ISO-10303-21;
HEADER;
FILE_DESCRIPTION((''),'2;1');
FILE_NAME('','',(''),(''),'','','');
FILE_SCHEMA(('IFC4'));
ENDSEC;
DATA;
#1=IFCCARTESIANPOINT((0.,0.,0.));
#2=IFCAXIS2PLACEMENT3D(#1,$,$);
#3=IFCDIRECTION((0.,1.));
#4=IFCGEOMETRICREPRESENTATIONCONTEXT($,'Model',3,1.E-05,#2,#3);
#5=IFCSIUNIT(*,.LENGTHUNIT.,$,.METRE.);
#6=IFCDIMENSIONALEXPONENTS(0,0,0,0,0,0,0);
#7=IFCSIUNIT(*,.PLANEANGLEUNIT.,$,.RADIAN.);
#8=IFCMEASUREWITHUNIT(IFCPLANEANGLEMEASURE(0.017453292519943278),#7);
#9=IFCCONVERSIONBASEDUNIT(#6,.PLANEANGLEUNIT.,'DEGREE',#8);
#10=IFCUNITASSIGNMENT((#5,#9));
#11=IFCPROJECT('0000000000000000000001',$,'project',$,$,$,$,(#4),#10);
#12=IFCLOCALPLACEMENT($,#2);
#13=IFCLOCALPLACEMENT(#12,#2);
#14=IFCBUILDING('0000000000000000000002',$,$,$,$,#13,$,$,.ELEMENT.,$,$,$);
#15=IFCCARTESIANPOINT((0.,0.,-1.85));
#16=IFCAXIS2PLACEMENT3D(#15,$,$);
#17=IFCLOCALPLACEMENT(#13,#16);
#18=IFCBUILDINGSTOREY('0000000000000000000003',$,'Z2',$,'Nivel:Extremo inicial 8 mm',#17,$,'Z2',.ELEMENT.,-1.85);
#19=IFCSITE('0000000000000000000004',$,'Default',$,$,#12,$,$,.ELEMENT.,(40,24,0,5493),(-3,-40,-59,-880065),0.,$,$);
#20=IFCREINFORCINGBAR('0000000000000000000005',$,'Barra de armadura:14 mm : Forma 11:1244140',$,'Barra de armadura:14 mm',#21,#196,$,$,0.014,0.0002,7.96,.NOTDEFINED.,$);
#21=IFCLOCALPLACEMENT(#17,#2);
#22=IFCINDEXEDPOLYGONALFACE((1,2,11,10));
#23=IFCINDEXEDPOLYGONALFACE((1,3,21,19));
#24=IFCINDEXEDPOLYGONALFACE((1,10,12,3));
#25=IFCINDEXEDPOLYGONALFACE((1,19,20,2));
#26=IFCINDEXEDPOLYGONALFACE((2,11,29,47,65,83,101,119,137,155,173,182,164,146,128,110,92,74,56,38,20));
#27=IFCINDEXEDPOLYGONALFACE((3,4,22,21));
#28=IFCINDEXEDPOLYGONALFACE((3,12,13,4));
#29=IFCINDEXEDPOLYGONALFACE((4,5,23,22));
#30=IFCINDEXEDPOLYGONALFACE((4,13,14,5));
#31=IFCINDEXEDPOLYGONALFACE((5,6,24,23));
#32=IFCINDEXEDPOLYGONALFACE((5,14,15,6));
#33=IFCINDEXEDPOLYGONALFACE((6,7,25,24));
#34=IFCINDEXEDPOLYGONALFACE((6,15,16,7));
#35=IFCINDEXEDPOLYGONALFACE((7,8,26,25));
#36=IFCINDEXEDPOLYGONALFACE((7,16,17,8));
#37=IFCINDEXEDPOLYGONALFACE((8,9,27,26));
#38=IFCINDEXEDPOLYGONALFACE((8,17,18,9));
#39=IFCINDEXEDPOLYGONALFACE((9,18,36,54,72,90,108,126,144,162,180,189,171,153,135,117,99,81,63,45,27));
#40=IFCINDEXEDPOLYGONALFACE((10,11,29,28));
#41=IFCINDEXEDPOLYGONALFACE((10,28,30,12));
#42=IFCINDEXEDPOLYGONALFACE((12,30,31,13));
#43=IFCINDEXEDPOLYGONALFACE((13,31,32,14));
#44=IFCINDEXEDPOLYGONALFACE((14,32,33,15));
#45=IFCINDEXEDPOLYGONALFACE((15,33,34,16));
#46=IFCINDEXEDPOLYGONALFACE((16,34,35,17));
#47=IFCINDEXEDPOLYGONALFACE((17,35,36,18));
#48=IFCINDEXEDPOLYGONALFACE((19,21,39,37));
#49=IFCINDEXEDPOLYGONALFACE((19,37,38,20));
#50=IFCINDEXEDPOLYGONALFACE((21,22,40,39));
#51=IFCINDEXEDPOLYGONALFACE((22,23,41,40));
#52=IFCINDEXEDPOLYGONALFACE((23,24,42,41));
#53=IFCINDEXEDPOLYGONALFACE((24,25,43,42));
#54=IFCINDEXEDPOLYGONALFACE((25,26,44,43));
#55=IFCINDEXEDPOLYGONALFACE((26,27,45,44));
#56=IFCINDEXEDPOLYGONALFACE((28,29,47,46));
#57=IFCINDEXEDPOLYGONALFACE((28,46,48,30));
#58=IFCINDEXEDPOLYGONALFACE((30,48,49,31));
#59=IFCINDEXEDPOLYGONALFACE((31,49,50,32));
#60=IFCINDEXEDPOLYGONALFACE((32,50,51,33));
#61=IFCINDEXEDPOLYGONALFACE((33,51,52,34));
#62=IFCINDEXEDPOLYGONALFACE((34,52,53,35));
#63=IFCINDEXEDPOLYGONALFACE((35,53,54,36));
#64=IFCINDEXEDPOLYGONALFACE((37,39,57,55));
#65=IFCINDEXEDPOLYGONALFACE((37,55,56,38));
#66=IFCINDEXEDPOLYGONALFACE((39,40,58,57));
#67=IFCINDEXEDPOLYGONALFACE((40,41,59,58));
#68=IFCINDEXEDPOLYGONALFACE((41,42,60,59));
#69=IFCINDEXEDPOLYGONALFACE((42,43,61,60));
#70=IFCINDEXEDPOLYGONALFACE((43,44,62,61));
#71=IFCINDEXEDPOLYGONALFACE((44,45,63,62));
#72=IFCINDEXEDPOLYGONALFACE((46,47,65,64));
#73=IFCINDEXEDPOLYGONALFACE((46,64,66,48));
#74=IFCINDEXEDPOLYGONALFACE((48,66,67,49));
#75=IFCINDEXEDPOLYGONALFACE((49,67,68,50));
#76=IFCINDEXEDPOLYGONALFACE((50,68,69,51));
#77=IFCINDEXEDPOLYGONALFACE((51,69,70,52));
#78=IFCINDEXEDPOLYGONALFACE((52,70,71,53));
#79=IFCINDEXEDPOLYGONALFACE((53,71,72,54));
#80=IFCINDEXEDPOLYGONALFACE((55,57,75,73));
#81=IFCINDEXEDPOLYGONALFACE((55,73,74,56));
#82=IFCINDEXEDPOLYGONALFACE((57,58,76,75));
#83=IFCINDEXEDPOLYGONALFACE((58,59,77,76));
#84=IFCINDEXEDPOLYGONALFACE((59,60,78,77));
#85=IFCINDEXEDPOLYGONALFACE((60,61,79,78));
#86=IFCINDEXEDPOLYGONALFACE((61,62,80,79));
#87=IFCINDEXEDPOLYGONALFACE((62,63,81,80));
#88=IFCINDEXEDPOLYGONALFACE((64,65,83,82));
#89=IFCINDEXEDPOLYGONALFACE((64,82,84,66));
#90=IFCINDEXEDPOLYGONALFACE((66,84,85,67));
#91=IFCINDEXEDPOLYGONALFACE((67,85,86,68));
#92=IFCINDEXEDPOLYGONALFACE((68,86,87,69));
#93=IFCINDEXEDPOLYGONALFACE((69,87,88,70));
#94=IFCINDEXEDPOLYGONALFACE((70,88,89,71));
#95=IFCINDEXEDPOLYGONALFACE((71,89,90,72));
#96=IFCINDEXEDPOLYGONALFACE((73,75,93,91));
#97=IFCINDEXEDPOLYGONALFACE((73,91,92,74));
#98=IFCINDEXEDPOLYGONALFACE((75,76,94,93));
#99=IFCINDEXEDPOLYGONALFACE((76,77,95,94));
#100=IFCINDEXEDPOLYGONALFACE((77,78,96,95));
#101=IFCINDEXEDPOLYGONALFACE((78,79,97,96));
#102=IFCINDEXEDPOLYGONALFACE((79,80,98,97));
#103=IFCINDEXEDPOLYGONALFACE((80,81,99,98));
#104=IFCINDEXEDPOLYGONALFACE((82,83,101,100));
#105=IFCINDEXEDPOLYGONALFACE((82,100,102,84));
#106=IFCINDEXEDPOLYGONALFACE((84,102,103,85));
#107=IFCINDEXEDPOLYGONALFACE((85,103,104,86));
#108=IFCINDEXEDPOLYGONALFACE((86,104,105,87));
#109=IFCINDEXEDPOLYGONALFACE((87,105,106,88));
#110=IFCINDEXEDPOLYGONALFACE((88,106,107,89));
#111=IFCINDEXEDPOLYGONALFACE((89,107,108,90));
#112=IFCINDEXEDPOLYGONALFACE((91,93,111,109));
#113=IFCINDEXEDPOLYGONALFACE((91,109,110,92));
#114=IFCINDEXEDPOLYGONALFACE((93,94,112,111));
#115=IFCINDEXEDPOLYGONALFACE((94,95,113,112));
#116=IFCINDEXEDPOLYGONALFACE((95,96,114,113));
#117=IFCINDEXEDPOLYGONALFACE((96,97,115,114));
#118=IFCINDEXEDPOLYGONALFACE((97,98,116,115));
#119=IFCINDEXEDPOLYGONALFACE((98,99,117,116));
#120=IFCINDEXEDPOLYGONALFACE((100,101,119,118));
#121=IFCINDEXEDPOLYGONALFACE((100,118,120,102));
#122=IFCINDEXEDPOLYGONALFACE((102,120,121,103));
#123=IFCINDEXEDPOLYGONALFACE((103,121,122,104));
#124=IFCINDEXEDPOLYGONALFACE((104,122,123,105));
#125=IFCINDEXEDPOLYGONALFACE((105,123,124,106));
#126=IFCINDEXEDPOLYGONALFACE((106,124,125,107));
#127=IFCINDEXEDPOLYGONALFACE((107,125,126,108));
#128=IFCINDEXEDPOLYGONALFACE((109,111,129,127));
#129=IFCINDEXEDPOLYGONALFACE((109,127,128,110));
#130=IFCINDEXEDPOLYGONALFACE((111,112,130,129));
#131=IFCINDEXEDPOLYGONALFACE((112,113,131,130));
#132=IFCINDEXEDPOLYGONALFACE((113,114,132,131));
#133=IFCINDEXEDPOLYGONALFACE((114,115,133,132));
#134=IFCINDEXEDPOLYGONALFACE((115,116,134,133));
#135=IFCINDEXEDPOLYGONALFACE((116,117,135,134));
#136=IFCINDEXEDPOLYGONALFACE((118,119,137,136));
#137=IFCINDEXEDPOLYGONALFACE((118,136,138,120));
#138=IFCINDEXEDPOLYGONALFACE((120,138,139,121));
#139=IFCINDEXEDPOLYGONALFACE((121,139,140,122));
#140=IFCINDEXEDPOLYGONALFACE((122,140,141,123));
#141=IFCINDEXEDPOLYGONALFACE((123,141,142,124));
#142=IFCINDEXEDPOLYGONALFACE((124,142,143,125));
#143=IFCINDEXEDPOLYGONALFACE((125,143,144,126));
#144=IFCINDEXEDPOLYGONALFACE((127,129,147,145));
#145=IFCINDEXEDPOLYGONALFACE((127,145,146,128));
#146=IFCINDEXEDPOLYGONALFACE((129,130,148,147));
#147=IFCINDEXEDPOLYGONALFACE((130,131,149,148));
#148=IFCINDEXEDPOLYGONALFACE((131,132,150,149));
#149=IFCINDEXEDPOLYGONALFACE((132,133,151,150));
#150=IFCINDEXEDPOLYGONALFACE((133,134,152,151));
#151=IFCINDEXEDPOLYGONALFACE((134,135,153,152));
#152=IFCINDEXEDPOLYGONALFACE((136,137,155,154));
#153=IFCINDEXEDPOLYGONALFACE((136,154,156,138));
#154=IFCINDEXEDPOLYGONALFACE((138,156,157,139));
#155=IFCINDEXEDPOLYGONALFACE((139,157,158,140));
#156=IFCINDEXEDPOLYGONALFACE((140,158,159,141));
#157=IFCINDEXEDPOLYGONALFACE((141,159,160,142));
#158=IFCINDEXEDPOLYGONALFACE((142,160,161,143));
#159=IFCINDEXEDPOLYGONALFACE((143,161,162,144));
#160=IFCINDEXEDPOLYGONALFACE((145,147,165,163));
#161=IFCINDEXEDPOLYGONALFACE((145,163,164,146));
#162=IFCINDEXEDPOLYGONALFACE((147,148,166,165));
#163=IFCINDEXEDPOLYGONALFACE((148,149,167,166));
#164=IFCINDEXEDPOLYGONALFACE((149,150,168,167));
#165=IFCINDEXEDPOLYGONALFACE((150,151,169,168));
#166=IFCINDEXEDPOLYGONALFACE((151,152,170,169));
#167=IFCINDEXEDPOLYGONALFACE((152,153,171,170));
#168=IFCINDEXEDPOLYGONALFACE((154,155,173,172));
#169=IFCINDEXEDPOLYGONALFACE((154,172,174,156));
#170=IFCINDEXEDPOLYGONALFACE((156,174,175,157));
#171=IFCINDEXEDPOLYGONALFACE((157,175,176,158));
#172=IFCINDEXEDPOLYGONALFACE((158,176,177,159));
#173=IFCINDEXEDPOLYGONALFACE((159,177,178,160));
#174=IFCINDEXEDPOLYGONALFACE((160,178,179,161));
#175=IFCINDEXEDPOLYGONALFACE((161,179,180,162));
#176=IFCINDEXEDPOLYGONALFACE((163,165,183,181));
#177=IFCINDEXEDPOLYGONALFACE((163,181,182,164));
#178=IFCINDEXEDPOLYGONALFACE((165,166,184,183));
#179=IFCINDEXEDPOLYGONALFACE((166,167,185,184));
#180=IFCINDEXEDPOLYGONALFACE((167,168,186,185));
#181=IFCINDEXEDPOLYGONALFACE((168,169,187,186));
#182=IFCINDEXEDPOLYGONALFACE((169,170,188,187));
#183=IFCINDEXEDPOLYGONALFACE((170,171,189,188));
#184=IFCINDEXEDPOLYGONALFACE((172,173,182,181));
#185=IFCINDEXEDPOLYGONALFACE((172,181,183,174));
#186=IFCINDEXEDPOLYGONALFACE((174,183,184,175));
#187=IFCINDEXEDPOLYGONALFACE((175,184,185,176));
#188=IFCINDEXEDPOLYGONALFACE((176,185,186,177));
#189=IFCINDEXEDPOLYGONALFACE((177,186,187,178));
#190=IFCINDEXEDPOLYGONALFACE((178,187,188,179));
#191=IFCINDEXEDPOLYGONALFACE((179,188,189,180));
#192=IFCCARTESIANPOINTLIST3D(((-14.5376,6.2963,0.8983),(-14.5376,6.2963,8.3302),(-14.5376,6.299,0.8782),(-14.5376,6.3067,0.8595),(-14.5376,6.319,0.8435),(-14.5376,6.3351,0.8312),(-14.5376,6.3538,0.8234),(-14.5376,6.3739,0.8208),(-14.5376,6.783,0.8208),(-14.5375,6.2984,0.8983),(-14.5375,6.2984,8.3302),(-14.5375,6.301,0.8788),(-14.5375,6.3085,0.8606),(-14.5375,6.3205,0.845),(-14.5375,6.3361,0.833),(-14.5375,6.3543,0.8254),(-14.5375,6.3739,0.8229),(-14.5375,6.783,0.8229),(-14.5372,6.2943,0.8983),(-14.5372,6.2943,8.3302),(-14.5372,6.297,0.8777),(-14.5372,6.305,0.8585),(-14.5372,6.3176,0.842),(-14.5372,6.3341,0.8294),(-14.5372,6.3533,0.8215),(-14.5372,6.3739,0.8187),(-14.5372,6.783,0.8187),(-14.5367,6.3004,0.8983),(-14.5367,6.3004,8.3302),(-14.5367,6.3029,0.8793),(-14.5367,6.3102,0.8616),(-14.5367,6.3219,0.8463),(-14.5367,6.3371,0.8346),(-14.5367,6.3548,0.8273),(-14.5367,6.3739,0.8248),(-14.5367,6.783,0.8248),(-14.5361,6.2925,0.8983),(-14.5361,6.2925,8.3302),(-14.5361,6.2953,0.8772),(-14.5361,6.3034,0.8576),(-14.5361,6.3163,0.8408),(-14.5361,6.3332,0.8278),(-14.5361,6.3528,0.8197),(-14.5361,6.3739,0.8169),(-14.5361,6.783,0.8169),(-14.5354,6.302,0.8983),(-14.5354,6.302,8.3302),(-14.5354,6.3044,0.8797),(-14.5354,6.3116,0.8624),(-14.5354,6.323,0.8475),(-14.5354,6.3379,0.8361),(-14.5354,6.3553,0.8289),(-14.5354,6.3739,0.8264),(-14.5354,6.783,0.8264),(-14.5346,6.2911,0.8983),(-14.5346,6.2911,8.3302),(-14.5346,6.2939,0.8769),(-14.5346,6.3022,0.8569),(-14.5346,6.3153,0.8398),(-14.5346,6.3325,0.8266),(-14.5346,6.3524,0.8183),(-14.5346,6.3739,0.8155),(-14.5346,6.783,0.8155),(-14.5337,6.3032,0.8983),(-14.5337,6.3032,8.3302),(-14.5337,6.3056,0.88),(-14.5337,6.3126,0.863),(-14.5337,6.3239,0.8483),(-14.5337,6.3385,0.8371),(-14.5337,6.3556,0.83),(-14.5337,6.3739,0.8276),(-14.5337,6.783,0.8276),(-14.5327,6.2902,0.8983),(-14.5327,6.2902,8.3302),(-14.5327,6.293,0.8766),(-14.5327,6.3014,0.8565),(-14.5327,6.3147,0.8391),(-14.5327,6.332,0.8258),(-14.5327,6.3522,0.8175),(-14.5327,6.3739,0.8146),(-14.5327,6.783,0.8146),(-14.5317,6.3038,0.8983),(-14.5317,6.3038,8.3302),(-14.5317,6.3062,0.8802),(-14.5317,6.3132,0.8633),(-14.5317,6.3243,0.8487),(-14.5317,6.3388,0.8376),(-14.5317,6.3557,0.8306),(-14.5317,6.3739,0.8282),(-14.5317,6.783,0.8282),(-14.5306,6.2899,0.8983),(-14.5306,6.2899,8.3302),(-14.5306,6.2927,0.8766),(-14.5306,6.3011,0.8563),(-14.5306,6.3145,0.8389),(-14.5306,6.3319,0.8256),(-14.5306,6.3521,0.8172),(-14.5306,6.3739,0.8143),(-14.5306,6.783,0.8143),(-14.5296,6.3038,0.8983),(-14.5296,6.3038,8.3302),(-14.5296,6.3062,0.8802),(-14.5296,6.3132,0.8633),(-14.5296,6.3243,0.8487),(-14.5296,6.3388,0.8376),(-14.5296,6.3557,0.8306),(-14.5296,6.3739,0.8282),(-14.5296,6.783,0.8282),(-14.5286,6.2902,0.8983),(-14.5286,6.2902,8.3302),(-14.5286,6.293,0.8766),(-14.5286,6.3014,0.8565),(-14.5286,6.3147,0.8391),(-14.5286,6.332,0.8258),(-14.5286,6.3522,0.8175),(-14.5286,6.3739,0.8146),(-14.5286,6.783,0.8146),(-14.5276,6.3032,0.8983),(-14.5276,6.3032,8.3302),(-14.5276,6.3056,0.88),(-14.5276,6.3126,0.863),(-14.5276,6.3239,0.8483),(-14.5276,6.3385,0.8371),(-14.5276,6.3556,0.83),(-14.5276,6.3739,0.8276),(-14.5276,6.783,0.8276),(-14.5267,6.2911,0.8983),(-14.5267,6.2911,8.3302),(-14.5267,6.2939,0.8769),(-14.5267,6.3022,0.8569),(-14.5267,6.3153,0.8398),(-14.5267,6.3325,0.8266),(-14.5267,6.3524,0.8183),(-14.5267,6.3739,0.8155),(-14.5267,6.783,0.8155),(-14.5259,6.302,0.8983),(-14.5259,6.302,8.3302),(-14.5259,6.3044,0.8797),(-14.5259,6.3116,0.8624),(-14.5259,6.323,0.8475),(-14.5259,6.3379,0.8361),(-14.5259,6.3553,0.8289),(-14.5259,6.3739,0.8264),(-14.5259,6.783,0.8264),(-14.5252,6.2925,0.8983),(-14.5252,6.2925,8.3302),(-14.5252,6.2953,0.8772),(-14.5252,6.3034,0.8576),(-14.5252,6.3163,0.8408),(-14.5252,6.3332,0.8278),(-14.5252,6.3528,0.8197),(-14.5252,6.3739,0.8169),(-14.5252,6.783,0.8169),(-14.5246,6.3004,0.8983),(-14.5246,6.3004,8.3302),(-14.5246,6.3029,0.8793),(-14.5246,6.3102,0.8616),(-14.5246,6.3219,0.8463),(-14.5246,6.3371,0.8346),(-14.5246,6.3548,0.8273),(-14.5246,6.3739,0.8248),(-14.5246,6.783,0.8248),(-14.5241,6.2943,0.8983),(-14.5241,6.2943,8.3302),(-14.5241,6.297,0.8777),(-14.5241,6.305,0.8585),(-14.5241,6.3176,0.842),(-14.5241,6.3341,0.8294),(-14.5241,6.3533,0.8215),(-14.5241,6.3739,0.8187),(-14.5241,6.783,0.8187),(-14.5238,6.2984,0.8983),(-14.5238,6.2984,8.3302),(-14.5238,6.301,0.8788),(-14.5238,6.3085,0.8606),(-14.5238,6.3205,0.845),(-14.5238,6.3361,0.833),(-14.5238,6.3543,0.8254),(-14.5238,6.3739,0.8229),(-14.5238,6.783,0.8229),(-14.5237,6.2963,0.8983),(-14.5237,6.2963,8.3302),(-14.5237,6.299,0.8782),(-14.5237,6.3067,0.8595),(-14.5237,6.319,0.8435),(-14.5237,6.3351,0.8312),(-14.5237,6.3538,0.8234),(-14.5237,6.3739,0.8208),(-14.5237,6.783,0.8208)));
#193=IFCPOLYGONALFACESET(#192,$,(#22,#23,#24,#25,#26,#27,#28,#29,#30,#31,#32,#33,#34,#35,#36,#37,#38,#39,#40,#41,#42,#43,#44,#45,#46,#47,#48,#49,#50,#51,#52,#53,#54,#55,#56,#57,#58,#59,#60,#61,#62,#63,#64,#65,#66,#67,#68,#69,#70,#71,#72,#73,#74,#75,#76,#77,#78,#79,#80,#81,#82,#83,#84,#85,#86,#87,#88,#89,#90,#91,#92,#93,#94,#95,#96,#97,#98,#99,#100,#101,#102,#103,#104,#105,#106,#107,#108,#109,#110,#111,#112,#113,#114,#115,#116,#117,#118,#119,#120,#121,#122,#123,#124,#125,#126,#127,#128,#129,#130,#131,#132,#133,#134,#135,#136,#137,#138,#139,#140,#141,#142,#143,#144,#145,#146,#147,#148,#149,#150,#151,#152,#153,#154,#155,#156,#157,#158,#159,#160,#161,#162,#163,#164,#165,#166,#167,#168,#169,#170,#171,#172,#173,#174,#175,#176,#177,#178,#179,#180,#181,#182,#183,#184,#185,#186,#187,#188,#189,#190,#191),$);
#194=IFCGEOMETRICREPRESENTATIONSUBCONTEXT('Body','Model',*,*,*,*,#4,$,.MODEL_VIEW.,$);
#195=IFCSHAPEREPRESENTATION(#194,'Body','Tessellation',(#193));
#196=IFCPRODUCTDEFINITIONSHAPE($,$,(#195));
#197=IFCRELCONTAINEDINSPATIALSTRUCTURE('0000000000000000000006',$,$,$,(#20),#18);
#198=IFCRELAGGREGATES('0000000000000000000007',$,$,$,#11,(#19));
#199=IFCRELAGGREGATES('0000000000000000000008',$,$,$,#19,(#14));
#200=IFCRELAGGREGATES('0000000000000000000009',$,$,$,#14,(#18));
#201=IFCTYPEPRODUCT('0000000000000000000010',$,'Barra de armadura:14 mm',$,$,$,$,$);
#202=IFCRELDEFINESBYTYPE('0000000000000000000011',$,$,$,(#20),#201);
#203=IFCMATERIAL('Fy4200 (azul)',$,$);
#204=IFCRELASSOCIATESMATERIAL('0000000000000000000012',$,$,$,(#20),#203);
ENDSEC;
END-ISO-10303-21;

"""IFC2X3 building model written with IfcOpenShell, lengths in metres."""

from ifc_helpers import new_model, entity, si_unit, converted_unit, direction, frame, origin, place, context, subcontext, project, spatial, material, type_object, element, save


model = new_model("IFC2X3")

# Units and contexts
model_context = context("Model", 3, precision=1e-05, world=origin(), true_north=direction((0.0, 1.0)))
body_context = subcontext(model_context, "Body", "Model", "MODEL_VIEW")
ifc_project = project(units=[si_unit("LENGTHUNIT", "METRE"), converted_unit("PLANEANGLEUNIT", "DEGREE", entity("IfcPlaneAngleMeasure", 0.017453292519943278), si_unit("PLANEANGLEUNIT", "RADIAN"), dimensions=[0, 0, 0, 0, 0, 0, 0])], contexts=[model_context])

# Site, building, storey
site_placement = place(None, origin())
site = spatial("IfcSite", under=ifc_project, at=site_placement, Name="Default", CompositionType="ELEMENT", RefLatitude=(40, 24, 0, 5493), RefLongitude=(-3, -40, -59, -880065), RefElevation=0.0)
building_placement = place(site_placement, origin())
building = spatial("IfcBuilding", under=site, at=building_placement, CompositionType="ELEMENT")
storey_placement = place(building_placement, frame((0.0, 0.0, -1.85)))
storey = spatial("IfcBuildingStorey", under=building, at=storey_placement, Name="Z2", ObjectType="Nivel:Extremo inicial 8 mm", LongName="Z2", CompositionType="ELEMENT", Elevation=-1.85)

# Reinforcing bar
ifc_material_1 = material(Name="Fy4200 (azul)")
type_product_1 = type_object("IfcTypeProduct", Name="Barra de armadura:14 mm")
reinforcing_bar_1_placement = place(storey_placement, origin())
element("IfcReinforcingBar", 1, at=reinforcing_bar_1_placement, inside=storey, type_object=type_product_1, material=ifc_material_1, Name="Barra de armadura:14 mm : Forma 11:1244140", ObjectType="Barra de armadura:14 mm", BarLength=7.96, BarRole="NOTDEFINED", CrossSectionArea=0.0002, NominalDiameter=0.014, context=body_context, shape_type="AdvancedSweptSolid", body=[
    entity("IfcSweptDiskSolid", entity("IfcCompositeCurve", [entity("IfcCompositeCurveSegment", "CONTINUOUS", True, entity("IfcPolyline", [entity("IfcCartesianPoint", [-14.5306, 6.2969, 8.3302]), entity("IfcCartesianPoint", [-14.5306, 6.2969, 0.8983])])), entity("IfcCompositeCurveSegment", "CONTINUOUS", True, entity("IfcTrimmedCurve", entity("IfcCircle", entity("IfcAxis2Placement3D", entity("IfcCartesianPoint", [-14.5306, 6.3739, 0.8983]), entity("IfcDirection", [1.0, 0.0, 0.0]), entity("IfcDirection", [0.0, 0.0, -1.0])), 0.077), [entity("IfcParameterValue", 270.0)], [entity("IfcParameterValue", 360.0)], True, "PARAMETER")), entity("IfcCompositeCurveSegment", "CONTINUOUS", True, entity("IfcPolyline", [entity("IfcCartesianPoint", [-14.5306, 6.3739, 0.8213]), entity("IfcCartesianPoint", [-14.5306, 6.783, 0.8213])]))], False), 0.007, None, 0.0, 92.0),
])

save(model, "model.ifc")
